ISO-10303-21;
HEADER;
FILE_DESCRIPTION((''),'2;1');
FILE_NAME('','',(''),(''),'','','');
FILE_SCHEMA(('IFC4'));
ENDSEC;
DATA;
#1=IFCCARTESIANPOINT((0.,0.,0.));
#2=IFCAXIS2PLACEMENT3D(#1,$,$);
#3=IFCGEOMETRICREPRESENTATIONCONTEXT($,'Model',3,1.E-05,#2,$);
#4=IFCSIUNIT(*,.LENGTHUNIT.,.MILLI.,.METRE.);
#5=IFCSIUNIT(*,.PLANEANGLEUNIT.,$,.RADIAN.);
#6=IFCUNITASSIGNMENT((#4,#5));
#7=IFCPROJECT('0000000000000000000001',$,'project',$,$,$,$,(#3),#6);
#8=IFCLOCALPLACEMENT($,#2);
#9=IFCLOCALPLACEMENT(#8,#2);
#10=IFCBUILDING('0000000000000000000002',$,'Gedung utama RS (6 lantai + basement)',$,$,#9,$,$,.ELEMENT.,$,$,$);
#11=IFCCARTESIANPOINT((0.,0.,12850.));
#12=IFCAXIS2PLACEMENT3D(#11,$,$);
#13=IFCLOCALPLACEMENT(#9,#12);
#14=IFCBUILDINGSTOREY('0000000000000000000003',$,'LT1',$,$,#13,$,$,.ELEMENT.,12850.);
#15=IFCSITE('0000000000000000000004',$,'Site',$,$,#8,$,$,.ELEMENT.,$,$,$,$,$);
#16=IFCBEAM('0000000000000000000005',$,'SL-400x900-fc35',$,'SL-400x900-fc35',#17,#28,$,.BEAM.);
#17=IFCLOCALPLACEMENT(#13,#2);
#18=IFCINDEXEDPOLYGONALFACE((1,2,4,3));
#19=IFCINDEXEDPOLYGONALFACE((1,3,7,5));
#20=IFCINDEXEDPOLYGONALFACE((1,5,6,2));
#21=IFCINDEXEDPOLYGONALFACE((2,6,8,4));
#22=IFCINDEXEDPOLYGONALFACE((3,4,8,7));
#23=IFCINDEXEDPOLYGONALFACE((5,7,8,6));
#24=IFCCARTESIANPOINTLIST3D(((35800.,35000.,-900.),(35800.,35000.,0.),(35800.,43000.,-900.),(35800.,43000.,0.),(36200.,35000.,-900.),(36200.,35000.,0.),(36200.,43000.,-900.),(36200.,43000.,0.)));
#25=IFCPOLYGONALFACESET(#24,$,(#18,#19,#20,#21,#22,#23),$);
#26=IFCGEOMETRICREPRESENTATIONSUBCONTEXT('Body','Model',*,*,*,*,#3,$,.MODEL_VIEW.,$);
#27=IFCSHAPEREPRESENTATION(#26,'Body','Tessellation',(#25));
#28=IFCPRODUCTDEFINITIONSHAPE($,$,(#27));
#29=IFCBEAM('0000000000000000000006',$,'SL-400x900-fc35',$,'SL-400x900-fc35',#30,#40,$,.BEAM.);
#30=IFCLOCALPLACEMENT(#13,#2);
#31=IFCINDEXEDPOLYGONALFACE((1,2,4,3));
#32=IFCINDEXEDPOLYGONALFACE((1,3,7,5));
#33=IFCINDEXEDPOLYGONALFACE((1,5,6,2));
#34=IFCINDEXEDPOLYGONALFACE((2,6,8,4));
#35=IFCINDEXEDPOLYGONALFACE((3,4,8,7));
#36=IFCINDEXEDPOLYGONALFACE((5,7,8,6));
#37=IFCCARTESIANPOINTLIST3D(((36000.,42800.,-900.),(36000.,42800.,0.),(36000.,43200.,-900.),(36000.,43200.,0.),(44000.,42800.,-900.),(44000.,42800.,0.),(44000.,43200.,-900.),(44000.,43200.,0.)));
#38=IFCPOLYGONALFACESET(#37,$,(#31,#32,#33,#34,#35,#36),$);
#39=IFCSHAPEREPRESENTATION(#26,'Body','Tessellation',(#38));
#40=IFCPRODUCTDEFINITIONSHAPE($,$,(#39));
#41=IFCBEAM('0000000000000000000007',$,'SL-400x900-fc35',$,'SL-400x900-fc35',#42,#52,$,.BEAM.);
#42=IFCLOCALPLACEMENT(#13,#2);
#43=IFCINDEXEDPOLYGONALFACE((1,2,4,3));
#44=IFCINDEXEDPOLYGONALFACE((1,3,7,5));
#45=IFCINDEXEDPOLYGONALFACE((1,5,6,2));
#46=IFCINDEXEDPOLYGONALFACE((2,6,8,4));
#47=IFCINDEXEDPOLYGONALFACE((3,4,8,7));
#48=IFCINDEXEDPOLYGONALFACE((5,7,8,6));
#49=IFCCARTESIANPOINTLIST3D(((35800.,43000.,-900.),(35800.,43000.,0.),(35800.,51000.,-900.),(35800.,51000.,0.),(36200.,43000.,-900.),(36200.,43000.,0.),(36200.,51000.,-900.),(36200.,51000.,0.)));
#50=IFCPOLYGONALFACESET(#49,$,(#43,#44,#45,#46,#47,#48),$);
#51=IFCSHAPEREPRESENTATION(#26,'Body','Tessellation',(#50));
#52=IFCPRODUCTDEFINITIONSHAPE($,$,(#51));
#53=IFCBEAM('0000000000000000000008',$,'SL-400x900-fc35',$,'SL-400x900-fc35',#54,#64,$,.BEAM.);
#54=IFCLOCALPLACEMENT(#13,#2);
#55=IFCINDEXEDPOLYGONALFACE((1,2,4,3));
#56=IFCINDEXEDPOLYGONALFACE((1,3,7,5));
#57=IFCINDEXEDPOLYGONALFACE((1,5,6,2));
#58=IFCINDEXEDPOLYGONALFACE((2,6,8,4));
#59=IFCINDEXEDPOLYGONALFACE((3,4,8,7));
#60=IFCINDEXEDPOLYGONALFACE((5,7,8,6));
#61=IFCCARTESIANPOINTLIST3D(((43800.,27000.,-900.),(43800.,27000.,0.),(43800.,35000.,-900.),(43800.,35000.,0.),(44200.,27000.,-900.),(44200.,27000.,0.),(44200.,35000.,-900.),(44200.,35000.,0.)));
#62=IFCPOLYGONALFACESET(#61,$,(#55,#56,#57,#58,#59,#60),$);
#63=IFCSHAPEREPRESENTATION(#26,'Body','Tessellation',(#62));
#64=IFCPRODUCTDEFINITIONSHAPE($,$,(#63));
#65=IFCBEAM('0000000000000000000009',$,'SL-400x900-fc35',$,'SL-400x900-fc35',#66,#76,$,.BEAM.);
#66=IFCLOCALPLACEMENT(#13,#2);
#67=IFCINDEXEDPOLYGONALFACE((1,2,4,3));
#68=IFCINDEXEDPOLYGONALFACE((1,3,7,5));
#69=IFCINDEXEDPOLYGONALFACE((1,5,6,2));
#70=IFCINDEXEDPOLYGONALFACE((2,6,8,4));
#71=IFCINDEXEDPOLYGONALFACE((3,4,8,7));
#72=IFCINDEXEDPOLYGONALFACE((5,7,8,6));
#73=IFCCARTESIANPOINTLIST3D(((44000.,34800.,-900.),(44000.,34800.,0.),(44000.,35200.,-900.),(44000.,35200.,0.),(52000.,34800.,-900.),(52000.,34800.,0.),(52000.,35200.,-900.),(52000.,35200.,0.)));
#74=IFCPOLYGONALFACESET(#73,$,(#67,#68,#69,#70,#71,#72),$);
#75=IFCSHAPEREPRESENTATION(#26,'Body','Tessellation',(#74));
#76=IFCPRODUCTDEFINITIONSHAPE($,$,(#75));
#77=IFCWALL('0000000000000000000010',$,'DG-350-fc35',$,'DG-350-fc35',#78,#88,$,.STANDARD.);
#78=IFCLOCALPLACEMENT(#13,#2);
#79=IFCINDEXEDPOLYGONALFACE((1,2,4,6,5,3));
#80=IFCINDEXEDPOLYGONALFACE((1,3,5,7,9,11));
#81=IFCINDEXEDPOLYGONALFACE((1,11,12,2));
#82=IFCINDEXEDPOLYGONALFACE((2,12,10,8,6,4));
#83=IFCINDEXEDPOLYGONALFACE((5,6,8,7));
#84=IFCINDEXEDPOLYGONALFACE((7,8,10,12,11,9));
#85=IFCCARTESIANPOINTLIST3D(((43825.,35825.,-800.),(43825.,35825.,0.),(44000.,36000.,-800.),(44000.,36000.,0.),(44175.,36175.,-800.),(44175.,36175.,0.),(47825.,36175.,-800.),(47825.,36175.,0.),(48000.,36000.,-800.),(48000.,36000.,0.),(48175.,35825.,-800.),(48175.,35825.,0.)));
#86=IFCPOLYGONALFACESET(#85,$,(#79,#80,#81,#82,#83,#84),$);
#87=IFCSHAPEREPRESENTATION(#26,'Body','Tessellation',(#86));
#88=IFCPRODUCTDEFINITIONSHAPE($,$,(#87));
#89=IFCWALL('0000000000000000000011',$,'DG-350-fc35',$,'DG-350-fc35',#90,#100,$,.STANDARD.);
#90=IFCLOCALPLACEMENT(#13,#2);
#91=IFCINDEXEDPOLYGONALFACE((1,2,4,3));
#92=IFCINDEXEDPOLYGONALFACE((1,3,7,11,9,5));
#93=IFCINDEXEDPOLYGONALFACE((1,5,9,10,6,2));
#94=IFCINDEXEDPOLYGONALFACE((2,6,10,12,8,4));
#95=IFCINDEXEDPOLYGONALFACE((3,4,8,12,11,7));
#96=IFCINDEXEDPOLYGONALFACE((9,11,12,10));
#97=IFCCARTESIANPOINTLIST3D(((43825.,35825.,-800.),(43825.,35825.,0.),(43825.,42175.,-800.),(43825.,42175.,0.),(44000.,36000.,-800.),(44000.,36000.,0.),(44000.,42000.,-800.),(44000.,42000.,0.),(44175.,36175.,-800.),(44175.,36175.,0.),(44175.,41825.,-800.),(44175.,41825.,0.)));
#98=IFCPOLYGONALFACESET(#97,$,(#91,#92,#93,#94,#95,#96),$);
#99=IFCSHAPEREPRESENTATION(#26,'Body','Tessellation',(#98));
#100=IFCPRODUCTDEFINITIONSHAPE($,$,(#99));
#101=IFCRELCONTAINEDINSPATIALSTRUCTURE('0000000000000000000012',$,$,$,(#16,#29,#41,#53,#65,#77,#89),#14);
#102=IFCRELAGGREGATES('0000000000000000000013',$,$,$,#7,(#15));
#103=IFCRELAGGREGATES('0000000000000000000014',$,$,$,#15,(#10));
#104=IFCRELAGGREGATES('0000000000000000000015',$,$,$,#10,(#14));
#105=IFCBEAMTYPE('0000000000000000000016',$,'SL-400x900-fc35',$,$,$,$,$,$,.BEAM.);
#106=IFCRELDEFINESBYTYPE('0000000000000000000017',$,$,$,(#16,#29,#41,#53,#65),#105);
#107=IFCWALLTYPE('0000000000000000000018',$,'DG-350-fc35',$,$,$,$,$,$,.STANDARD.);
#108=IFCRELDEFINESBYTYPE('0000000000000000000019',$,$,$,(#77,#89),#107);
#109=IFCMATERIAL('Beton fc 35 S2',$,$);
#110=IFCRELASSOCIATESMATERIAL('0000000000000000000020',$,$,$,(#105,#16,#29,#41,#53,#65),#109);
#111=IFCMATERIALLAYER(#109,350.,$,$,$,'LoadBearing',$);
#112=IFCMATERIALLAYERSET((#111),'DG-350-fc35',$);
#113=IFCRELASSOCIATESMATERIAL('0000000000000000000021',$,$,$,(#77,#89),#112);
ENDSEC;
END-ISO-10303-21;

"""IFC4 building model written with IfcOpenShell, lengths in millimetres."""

from ifc_helpers import new_model, si_unit, frame, origin, origin_2d, place, context, subcontext, project, spatial, polyline, rectangle, outline, extrude, material, layer, layer_set, layer_usage, material_profile, profile_set, profile_usage, type_object, element, save


model = new_model("IFC4")

# Units and contexts
model_context = context("Model", 3, precision=1e-05, world=origin())
body_context = subcontext(model_context, "Body", "Model", "MODEL_VIEW")
ifc_project = project(units=[si_unit("LENGTHUNIT", "METRE", prefix="MILLI"), si_unit("PLANEANGLEUNIT", "RADIAN")], contexts=[model_context])

# Site, building, storey
site_placement = place(None, origin())
site = spatial("IfcSite", under=ifc_project, at=site_placement, Name="Site", CompositionType="ELEMENT")
building_placement = place(site_placement, origin())
building = spatial("IfcBuilding", under=site, at=building_placement, Name="Gedung utama RS (6 lantai + basement)", CompositionType="ELEMENT")
storey_placement = place(building_placement, frame((0.0, 0.0, 12850.0)))
storey = spatial("IfcBuildingStorey", under=building, at=storey_placement, Name="LT1", CompositionType="ELEMENT", Elevation=12850.0)

# Beams
ifc_material = material(Name="Beton fc 35 S2")
ifc_material_profile_1 = material_profile(ifc_material, rectangle(XDim=400.0, YDim=900.0, at=origin_2d()), Name="SL-400x900-fc35")
ifc_profile_set_1 = profile_set([ifc_material_profile_1], Name="SL-400x900-fc35")
ifc_profile_usage_1 = profile_usage(ifc_profile_set_1, cardinal=8)
beam_type_1 = type_object("IfcBeamType", Name="SL-400x900-fc35", PredefinedType="BEAM", material=ifc_profile_set_1)
beam_1_placement = place(storey_placement, frame((36000.0, 35000.0, -450.0)))
element("IfcBeam", 1, at=beam_1_placement, inside=storey, type_object=beam_type_1, material=ifc_profile_usage_1, Name="SL-400x900-fc35", ObjectType="SL-400x900-fc35", PredefinedType="BEAM", context=body_context, shape_type="SweptSolid", body=[
    extrude(rectangle(XDim=400.0, YDim=900.0, at=origin_2d()), frame((0.0, 0.0, 0.0), z_axis=(0.0, 1.0, 0.0), x_axis=(-1.0, 0.0, 0.0)), (0.0, 0.0, 1.0), 8000.0),
])
beam_2_placement = place(storey_placement, frame((36000.0, 43000.0, -450.0)))
element("IfcBeam", 2, at=beam_2_placement, inside=storey, type_object=beam_type_1, material=ifc_profile_usage_1, Name="SL-400x900-fc35", ObjectType="SL-400x900-fc35", PredefinedType="BEAM", context=body_context, shape_type="SweptSolid", body=[
    extrude(rectangle(XDim=400.0, YDim=900.0, at=origin_2d()), frame((0.0, 0.0, 0.0), z_axis=(1.0, 0.0, 0.0), x_axis=(0.0, 1.0, 0.0)), (0.0, 0.0, 1.0), 8000.0),
])
for number, where, name in (
    (3, (36000.0, 43000.0, -450.0), "SL-400x900-fc35"),
    (4, (44000.0, 27000.0, -450.0), "SL-400x900-fc35"),
):
    element("IfcBeam", number, at=place(storey_placement, frame(where)), inside=storey, type_object=beam_type_1, material=ifc_profile_usage_1, Name=name, ObjectType="SL-400x900-fc35", PredefinedType="BEAM", context=body_context, shape_type="SweptSolid", body=[
        extrude(rectangle(XDim=400.0, YDim=900.0, at=origin_2d()), frame((0.0, 0.0, 0.0), z_axis=(0.0, 1.0, 0.0), x_axis=(-1.0, 0.0, 0.0)), (0.0, 0.0, 1.0), 8000.0),
    ])
beam_3_placement = place(storey_placement, frame((44000.0, 35000.0, -450.0)))
element("IfcBeam", 5, at=beam_3_placement, inside=storey, type_object=beam_type_1, material=ifc_profile_usage_1, Name="SL-400x900-fc35", ObjectType="SL-400x900-fc35", PredefinedType="BEAM", context=body_context, shape_type="SweptSolid", body=[
    extrude(rectangle(XDim=400.0, YDim=900.0, at=origin_2d()), frame((0.0, 0.0, 0.0), z_axis=(1.0, 0.0, 0.0), x_axis=(0.0, 1.0, 0.0)), (0.0, 0.0, 1.0), 8000.0),
])

# Walls
ifc_layer = layer(ifc_material, 350.0, Category="LoadBearing")
ifc_layer_set = layer_set([ifc_layer], Name="DG-350-fc35")
ifc_layer_usage = layer_usage(ifc_layer_set, "AXIS2", "NEGATIVE", 175.0)
wall_type = type_object("IfcWallType", Name="DG-350-fc35", PredefinedType="STANDARD")
wall_1_placement = place(storey_placement, frame((44000.0, 36000.0, -800.0), z_axis=(0.0, 0.0, 1.0), x_axis=(1.0, 0.0, 0.0)))
element("IfcWall", 6, at=wall_1_placement, inside=storey, type_object=wall_type, material=ifc_layer_usage, Name="DG-350-fc35", ObjectType="DG-350-fc35", PredefinedType="STANDARD", context=body_context, shape_type="SweptSolid", body=[
    extrude(outline(polyline([(-175.0, -175.0), (0.0, 0.0), (175.0, 175.0), (3825.0, 175.0), (4000.0, 0.0), (4175.0, -175.0), (-175.0, -175.0)])), origin(), (0.0, 0.0, 1.0), 800.0),
])
wall_2_placement = place(storey_placement, frame((44000.0, 42000.0, -800.0), z_axis=(0.0, 0.0, 1.0), x_axis=(0.0, -1.0, 0.0)))
element("IfcWall", 7, at=wall_2_placement, inside=storey, type_object=wall_type, material=ifc_layer_usage, Name="DG-350-fc35", ObjectType="DG-350-fc35", PredefinedType="STANDARD", context=body_context, shape_type="SweptSolid", body=[
    extrude(outline(polyline([(-175.0, -175.0), (0.0, 0.0), (175.0, 175.0), (5825.0, 175.0), (6000.0, 0.0), (6175.0, -175.0), (-175.0, -175.0)])), origin(), (0.0, 0.0, 1.0), 800.0),
])

save(model, "model.ifc")
